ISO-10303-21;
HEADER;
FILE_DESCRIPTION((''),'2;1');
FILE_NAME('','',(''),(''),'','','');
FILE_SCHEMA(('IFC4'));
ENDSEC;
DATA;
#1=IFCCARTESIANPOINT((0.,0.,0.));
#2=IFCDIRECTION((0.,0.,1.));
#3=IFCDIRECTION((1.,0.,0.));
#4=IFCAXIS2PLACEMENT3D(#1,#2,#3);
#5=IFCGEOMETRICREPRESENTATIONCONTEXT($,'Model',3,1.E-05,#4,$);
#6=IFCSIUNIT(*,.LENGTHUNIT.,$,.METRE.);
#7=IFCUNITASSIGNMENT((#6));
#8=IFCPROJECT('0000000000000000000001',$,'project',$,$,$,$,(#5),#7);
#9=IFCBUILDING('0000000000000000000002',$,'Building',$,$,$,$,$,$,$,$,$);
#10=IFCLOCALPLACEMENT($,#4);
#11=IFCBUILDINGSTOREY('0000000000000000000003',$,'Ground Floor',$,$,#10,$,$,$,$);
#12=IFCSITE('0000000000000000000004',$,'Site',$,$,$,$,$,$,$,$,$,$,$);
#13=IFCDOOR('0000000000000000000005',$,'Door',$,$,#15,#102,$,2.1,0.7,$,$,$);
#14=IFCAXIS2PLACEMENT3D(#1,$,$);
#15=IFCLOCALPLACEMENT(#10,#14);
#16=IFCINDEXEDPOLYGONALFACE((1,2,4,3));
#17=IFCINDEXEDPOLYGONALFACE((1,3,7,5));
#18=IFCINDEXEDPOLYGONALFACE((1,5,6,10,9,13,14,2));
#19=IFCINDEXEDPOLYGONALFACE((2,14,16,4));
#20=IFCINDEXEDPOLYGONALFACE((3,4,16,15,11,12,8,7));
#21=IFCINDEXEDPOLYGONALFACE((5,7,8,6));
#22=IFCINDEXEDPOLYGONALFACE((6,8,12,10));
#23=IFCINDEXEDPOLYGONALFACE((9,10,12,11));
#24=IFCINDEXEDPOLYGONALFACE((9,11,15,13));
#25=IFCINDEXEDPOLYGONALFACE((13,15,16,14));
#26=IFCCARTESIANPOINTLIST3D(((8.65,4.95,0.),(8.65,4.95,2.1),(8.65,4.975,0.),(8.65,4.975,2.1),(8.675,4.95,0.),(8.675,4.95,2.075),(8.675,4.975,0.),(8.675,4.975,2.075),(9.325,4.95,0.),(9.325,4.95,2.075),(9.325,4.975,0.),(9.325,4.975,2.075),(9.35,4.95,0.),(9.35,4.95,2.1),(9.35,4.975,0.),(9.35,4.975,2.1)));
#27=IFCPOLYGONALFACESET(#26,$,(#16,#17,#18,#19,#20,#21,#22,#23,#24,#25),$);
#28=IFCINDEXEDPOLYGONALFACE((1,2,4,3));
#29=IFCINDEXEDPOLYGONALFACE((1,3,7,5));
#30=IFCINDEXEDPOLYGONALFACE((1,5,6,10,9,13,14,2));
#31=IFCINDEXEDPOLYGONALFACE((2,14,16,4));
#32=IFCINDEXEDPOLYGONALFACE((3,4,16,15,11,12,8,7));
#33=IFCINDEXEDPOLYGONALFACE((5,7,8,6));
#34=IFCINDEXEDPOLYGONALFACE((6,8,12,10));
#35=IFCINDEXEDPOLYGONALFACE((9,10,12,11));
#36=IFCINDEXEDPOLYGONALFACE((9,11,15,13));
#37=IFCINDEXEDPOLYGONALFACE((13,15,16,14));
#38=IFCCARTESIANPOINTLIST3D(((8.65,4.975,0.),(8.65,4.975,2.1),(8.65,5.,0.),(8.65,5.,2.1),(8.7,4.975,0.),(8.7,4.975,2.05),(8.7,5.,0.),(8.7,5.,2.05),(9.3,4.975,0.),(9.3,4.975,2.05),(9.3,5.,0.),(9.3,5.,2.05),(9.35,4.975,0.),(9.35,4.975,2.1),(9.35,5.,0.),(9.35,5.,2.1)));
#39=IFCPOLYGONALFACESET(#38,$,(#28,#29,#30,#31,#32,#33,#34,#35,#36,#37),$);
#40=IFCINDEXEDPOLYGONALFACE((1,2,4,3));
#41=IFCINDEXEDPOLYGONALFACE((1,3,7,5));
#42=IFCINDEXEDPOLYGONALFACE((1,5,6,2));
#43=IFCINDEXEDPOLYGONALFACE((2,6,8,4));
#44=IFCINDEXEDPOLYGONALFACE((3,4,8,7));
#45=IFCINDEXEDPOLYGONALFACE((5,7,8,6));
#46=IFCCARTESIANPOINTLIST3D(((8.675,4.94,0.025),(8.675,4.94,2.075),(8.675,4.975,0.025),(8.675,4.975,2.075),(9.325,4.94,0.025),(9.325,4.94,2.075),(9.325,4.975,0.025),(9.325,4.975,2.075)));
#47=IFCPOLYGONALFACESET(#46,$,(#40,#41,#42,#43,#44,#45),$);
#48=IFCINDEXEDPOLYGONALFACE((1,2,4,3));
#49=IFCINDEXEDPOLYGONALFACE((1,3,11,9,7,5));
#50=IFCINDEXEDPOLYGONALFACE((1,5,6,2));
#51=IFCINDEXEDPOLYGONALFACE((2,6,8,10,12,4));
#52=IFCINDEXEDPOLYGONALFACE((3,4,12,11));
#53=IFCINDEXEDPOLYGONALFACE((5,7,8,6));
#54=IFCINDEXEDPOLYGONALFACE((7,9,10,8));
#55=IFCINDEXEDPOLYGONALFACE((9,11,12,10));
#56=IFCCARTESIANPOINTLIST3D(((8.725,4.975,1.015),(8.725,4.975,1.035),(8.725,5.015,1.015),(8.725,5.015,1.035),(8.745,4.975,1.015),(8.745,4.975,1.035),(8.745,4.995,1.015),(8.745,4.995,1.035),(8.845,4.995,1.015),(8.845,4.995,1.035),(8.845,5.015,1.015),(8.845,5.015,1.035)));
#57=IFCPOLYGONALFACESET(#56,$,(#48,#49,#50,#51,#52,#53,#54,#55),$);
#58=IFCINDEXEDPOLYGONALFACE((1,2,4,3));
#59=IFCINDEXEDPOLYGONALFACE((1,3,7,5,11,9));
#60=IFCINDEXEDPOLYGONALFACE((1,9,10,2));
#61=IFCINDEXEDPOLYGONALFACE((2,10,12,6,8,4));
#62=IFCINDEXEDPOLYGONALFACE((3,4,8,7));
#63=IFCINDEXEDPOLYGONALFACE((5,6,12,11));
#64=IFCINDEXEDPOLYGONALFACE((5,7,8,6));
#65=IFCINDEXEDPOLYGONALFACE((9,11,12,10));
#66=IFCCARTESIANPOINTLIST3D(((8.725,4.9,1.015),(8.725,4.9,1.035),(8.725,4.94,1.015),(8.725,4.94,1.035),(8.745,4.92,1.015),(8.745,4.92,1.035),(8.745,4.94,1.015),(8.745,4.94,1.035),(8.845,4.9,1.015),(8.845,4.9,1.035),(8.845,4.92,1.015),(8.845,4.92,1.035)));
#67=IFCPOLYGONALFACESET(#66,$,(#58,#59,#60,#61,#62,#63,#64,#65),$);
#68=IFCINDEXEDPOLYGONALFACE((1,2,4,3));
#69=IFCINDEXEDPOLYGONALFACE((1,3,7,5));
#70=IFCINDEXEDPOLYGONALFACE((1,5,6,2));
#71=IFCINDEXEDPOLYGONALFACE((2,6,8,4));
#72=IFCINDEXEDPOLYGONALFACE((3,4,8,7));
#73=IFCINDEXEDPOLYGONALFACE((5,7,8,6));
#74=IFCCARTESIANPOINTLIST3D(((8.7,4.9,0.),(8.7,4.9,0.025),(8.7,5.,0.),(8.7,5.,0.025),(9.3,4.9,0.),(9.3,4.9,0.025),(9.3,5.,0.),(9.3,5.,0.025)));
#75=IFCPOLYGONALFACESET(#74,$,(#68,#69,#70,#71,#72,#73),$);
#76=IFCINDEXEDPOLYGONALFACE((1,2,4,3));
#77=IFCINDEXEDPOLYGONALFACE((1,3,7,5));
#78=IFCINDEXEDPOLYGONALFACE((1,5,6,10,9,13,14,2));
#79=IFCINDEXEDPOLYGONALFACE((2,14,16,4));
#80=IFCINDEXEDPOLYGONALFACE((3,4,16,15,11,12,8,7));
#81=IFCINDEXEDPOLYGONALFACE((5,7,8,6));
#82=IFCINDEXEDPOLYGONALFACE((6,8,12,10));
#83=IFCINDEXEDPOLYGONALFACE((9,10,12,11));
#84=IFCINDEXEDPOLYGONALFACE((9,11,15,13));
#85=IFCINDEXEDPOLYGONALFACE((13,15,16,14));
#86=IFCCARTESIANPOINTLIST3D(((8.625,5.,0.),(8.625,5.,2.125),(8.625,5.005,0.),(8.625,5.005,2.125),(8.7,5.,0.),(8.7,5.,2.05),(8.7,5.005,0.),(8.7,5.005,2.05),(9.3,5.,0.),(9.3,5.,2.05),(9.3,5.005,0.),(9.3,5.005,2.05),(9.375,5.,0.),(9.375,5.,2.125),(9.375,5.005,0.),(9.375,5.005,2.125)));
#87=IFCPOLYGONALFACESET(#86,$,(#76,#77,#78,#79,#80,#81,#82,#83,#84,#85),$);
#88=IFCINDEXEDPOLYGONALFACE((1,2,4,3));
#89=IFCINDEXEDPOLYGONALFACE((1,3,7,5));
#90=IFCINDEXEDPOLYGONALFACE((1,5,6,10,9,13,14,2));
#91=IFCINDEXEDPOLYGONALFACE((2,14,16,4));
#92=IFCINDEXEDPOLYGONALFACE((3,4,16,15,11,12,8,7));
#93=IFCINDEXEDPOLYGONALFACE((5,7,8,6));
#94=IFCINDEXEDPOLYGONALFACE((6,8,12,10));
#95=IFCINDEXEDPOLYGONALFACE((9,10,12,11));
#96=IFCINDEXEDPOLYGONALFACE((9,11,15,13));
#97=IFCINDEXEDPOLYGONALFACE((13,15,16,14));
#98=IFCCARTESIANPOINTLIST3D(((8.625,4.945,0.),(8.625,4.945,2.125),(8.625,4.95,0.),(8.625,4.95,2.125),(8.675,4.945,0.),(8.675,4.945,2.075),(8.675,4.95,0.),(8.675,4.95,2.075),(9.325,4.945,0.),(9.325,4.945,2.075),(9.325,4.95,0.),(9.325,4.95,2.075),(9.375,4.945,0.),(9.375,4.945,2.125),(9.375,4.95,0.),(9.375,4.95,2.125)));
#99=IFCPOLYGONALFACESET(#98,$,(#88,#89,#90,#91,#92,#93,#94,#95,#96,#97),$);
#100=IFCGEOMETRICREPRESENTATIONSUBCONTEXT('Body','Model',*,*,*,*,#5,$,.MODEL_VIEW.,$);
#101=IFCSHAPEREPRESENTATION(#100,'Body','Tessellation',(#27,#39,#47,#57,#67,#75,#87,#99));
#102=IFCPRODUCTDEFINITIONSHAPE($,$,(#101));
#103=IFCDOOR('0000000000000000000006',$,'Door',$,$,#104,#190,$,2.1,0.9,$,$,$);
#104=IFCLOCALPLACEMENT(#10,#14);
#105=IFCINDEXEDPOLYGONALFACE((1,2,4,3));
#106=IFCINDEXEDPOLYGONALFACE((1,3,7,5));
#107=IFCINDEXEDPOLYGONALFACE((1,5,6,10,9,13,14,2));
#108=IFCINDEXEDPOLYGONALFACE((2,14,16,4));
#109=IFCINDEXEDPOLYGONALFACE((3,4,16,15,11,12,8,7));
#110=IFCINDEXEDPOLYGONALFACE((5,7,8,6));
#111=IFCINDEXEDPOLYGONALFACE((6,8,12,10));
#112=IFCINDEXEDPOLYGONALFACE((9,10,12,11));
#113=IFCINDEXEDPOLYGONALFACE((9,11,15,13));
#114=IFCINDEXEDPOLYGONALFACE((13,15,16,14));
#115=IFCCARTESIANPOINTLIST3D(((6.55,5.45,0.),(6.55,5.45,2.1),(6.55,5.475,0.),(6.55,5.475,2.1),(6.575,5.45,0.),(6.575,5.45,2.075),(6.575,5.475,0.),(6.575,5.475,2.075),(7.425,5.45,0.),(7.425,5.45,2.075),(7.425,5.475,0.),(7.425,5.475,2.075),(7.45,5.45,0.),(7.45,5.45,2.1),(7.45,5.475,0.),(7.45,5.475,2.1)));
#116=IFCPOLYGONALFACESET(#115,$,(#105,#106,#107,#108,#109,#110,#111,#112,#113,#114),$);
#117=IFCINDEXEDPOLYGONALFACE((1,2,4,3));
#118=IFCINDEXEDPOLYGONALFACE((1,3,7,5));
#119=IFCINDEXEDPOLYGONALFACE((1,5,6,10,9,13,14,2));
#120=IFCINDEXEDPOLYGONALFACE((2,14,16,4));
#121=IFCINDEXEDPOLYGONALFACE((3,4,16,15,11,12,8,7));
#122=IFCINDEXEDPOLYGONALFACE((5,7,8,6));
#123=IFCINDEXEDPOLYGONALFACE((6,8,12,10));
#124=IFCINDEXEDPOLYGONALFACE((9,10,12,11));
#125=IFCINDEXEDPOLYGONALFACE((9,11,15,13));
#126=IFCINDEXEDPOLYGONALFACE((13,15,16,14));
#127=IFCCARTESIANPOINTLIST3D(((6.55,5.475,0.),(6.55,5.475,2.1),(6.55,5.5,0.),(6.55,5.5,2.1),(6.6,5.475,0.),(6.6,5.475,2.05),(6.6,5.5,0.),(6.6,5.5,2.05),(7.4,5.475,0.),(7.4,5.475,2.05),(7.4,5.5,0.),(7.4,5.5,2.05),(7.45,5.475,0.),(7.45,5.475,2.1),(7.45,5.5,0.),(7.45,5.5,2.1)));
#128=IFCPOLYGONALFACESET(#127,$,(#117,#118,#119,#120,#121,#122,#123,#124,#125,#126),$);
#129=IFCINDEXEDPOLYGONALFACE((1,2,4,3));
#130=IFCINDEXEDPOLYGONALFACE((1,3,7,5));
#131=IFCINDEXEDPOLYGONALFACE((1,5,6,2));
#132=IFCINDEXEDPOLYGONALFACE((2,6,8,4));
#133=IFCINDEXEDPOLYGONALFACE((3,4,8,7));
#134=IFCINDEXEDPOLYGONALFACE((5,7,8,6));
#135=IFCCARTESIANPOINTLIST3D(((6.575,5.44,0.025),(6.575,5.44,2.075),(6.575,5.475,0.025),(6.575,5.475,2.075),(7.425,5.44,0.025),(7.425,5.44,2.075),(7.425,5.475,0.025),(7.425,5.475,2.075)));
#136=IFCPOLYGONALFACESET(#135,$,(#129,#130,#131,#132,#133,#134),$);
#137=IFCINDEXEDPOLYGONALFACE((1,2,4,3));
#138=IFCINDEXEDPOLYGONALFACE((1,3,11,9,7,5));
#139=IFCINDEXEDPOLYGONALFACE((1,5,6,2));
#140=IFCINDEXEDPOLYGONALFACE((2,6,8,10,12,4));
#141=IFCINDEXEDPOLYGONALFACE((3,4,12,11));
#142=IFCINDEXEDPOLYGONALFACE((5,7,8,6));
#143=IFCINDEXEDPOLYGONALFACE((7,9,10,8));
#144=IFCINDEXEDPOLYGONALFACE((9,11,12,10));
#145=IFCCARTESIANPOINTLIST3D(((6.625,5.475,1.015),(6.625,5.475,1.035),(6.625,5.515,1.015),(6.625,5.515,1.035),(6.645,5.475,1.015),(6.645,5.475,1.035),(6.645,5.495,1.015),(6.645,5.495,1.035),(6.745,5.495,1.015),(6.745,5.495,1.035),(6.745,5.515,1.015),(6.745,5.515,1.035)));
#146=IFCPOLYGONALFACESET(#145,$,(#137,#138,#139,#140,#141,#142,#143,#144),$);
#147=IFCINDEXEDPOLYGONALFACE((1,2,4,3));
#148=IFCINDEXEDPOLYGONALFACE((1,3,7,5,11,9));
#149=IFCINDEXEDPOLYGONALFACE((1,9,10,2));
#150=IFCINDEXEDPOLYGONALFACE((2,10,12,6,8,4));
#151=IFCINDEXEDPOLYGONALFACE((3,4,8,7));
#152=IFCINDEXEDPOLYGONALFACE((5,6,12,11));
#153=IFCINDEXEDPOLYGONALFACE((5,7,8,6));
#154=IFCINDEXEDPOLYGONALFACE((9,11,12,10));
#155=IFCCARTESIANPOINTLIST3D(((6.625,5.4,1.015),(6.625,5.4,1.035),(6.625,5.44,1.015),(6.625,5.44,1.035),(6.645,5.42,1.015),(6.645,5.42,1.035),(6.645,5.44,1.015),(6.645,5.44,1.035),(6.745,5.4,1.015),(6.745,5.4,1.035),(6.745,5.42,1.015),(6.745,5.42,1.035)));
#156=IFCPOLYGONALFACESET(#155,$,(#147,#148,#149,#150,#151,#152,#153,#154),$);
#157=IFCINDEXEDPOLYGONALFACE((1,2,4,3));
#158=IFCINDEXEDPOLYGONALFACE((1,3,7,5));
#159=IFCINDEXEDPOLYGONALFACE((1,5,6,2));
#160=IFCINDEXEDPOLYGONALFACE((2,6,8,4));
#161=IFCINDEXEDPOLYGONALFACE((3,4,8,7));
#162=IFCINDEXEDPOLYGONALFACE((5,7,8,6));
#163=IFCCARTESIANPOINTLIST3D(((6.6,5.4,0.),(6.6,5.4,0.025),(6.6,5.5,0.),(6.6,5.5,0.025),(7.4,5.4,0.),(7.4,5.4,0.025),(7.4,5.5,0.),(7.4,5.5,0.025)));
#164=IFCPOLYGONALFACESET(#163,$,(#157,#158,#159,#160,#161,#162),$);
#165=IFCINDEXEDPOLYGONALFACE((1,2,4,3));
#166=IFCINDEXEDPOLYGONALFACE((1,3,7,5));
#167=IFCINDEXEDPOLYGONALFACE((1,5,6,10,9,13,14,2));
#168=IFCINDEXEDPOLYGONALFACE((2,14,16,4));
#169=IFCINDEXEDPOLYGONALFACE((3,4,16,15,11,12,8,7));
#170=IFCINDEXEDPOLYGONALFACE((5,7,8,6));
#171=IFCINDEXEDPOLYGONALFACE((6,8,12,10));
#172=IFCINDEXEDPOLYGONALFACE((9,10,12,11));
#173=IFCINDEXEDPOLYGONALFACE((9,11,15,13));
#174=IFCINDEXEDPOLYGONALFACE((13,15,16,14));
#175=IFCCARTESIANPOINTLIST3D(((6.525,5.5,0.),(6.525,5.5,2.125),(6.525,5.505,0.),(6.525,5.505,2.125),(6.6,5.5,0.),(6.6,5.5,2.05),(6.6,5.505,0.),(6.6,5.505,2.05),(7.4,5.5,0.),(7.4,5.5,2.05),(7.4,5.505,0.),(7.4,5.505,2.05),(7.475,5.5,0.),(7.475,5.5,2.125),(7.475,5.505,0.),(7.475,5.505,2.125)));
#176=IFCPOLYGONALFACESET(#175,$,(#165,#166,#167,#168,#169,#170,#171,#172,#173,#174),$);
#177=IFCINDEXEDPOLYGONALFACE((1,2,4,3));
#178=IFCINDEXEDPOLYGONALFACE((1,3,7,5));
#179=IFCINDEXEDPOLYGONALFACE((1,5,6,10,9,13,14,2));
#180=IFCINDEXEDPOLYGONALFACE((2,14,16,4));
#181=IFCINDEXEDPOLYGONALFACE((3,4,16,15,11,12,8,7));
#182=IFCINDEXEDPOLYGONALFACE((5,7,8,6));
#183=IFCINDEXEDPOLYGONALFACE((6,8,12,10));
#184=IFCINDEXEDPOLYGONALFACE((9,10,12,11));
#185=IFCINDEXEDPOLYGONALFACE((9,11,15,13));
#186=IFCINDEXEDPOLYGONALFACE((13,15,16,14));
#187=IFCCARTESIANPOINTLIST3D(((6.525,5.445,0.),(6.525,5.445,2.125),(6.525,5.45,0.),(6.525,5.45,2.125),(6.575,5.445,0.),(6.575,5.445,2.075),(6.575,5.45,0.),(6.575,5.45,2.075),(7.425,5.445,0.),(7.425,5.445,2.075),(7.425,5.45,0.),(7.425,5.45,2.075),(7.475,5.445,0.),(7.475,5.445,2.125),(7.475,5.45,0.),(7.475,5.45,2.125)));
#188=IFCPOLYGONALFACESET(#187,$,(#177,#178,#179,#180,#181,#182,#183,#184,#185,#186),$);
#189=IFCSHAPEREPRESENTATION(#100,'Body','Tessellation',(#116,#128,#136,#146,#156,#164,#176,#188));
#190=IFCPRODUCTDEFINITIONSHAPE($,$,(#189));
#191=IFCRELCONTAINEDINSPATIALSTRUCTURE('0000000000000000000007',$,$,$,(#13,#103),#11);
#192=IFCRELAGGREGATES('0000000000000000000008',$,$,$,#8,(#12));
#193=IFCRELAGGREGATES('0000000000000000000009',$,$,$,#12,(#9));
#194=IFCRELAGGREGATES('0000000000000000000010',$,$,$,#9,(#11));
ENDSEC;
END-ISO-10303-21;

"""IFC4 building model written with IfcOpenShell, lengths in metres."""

from ifc_helpers import new_model, si_unit, frame, origin_with_axes, place, context, subcontext, project, spatial, line, indexed_curve, outline, extrude, element, save


model = new_model("IFC4")

# Units and contexts
model_context = context("Model", 3, precision=1e-05, world=origin_with_axes())
body_context = subcontext(model_context, "Body", "Model", "MODEL_VIEW")
ifc_project = project(units=[si_unit("LENGTHUNIT", "METRE")], contexts=[model_context])

# Site, building, storey
site = spatial("IfcSite", under=ifc_project, Name="Site")
building = spatial("IfcBuilding", under=site, Name="Building")
storey_placement = place(None, origin_with_axes())
storey = spatial("IfcBuildingStorey", under=building, at=storey_placement, Name="Ground Floor")

# Doors
door_1_placement = place(storey_placement, frame((9.35, 5.0, 0.0), z_axis=(0.0, 0.0, 1.0), x_axis=(-1.0, 0.0, 0.0)))
element("IfcDoor", 1, at=door_1_placement, inside=storey, Name="Door", OverallHeight=2.1, OverallWidth=0.7, context=body_context, shape_type="SweptSolid", body=[
    extrude(outline(indexed_curve([(0.0, 0.0), (0.0, 2.1), (0.7, 2.1), (0.7, 0.0), (0.675, 0.0), (0.675, 2.075), (0.025, 2.075), (0.025, 0.0)], segments=[line(1, 2, 3, 4, 5, 6, 7, 8, 1)])), frame((0.0, 0.025, 0.0), z_axis=(0.0, -1.0, 0.0), x_axis=(1.0, 0.0, 0.0)), (0.0, 0.0, -1.0), 0.025),
    extrude(outline(indexed_curve([(0.0, 0.0), (0.0, 2.1), (0.7, 2.1), (0.7, 0.0), (0.65, 0.0), (0.65, 2.05), (0.05, 2.05), (0.05, 0.0)], segments=[line(1, 2, 3, 4, 5, 6, 7, 8, 1)])), frame((0.0, 0.0, 0.0), z_axis=(0.0, -1.0, 0.0), x_axis=(1.0, 0.0, 0.0)), (0.0, 0.0, -1.0), 0.025),
    extrude(outline(indexed_curve([(0.0, 0.0), (0.65, 0.0), (0.65, 0.035), (0.0, 0.035)], segments=[line(1, 2, 3, 4, 1)])), frame((0.025, 0.025, 0.025), z_axis=(0.0, 0.0, 1.0), x_axis=(1.0, 0.0, 0.0)), (0.0, 0.0, 1.0), 2.05),
    extrude(outline(indexed_curve([(0.0, 0.0), (0.0, -0.04), (-0.12, -0.04), (-0.12, -0.02), (-0.02, -0.02), (-0.02, 0.0)], segments=[line(1, 2, 3, 4, 5, 6, 1)])), frame((0.625, 0.025, 1.015), z_axis=(0.0, 0.0, 1.0), x_axis=(1.0, 0.0, 0.0)), (0.0, 0.0, 1.0), 0.02),
    extrude(outline(indexed_curve([(0.0, 0.0), (0.0, 0.04), (-0.12, 0.04), (-0.12, 0.02), (-0.02, 0.02), (-0.02, 0.0)], segments=[line(1, 2, 3, 4, 5, 6, 1)])), frame((0.625, 0.06, 1.015), z_axis=(0.0, 0.0, 1.0), x_axis=(1.0, 0.0, 0.0)), (0.0, 0.0, 1.0), 0.02),
    extrude(outline(indexed_curve([(0.0, 0.0), (0.6, 0.0), (0.6, 0.1), (0.0, 0.1)], segments=[line(1, 2, 3, 4, 1)])), frame((0.05, 0.0, 0.0), z_axis=(0.0, 0.0, 1.0), x_axis=(1.0, 0.0, 0.0)), (0.0, 0.0, 1.0), 0.025),
    extrude(outline(indexed_curve([(0.0, 0.0), (0.0, 2.125), (0.75, 2.125), (0.75, 0.0), (0.675, 0.0), (0.675, 2.05), (0.075, 2.05), (0.075, 0.0)], segments=[line(1, 2, 3, 4, 5, 6, 7, 8, 1)])), frame((-0.025, -0.005, 0.0), z_axis=(0.0, -1.0, 0.0), x_axis=(1.0, 0.0, 0.0)), (0.0, 0.0, -1.0), 0.005),
    extrude(outline(indexed_curve([(0.0, 0.0), (0.0, 2.125), (0.75, 2.125), (0.75, 0.0), (0.7, 0.0), (0.7, 2.075), (0.05, 2.075), (0.05, 0.0)], segments=[line(1, 2, 3, 4, 5, 6, 7, 8, 1)])), frame((-0.025, 0.05, 0.0), z_axis=(0.0, -1.0, 0.0), x_axis=(1.0, 0.0, 0.0)), (0.0, 0.0, -1.0), 0.005),
])
door_2_placement = place(storey_placement, frame((7.45, 5.5, 0.0), z_axis=(0.0, 0.0, 1.0), x_axis=(-1.0, 0.0, 0.0)))
element("IfcDoor", 2, at=door_2_placement, inside=storey, Name="Door", OverallHeight=2.1, OverallWidth=0.9, context=body_context, shape_type="SweptSolid", body=[
    extrude(outline(indexed_curve([(0.0, 0.0), (0.0, 2.1), (0.9, 2.1), (0.9, 0.0), (0.875, 0.0), (0.875, 2.075), (0.025, 2.075), (0.025, 0.0)], segments=[line(1, 2, 3, 4, 5, 6, 7, 8, 1)])), frame((0.0, 0.025, 0.0), z_axis=(0.0, -1.0, 0.0), x_axis=(1.0, 0.0, 0.0)), (0.0, 0.0, -1.0), 0.025),
    extrude(outline(indexed_curve([(0.0, 0.0), (0.0, 2.1), (0.9, 2.1), (0.9, 0.0), (0.85, 0.0), (0.85, 2.05), (0.05, 2.05), (0.05, 0.0)], segments=[line(1, 2, 3, 4, 5, 6, 7, 8, 1)])), frame((0.0, 0.0, 0.0), z_axis=(0.0, -1.0, 0.0), x_axis=(1.0, 0.0, 0.0)), (0.0, 0.0, -1.0), 0.025),
    extrude(outline(indexed_curve([(0.0, 0.0), (0.85, 0.0), (0.85, 0.035), (0.0, 0.035)], segments=[line(1, 2, 3, 4, 1)])), frame((0.025, 0.025, 0.025), z_axis=(0.0, 0.0, 1.0), x_axis=(1.0, 0.0, 0.0)), (0.0, 0.0, 1.0), 2.05),
    extrude(outline(indexed_curve([(0.0, 0.0), (0.0, -0.04), (-0.12, -0.04), (-0.12, -0.02), (-0.02, -0.02), (-0.02, 0.0)], segments=[line(1, 2, 3, 4, 5, 6, 1)])), frame((0.825, 0.025, 1.015), z_axis=(0.0, 0.0, 1.0), x_axis=(1.0, 0.0, 0.0)), (0.0, 0.0, 1.0), 0.02),
    extrude(outline(indexed_curve([(0.0, 0.0), (0.0, 0.04), (-0.12, 0.04), (-0.12, 0.02), (-0.02, 0.02), (-0.02, 0.0)], segments=[line(1, 2, 3, 4, 5, 6, 1)])), frame((0.825, 0.06, 1.015), z_axis=(0.0, 0.0, 1.0), x_axis=(1.0, 0.0, 0.0)), (0.0, 0.0, 1.0), 0.02),
    extrude(outline(indexed_curve([(0.0, 0.0), (0.8, 0.0), (0.8, 0.1), (0.0, 0.1)], segments=[line(1, 2, 3, 4, 1)])), frame((0.05, 0.0, 0.0), z_axis=(0.0, 0.0, 1.0), x_axis=(1.0, 0.0, 0.0)), (0.0, 0.0, 1.0), 0.025),
    extrude(outline(indexed_curve([(0.0, 0.0), (0.0, 2.125), (0.95, 2.125), (0.95, 0.0), (0.875, 0.0), (0.875, 2.05), (0.075, 2.05), (0.075, 0.0)], segments=[line(1, 2, 3, 4, 5, 6, 7, 8, 1)])), frame((-0.025, -0.005, 0.0), z_axis=(0.0, -1.0, 0.0), x_axis=(1.0, 0.0, 0.0)), (0.0, 0.0, -1.0), 0.005),
    extrude(outline(indexed_curve([(0.0, 0.0), (0.0, 2.125), (0.95, 2.125), (0.95, 0.0), (0.9, 0.0), (0.9, 2.075), (0.05, 2.075), (0.05, 0.0)], segments=[line(1, 2, 3, 4, 5, 6, 7, 8, 1)])), frame((-0.025, 0.05, 0.0), z_axis=(0.0, -1.0, 0.0), x_axis=(1.0, 0.0, 0.0)), (0.0, 0.0, -1.0), 0.005),
])

save(model, "model.ifc")
